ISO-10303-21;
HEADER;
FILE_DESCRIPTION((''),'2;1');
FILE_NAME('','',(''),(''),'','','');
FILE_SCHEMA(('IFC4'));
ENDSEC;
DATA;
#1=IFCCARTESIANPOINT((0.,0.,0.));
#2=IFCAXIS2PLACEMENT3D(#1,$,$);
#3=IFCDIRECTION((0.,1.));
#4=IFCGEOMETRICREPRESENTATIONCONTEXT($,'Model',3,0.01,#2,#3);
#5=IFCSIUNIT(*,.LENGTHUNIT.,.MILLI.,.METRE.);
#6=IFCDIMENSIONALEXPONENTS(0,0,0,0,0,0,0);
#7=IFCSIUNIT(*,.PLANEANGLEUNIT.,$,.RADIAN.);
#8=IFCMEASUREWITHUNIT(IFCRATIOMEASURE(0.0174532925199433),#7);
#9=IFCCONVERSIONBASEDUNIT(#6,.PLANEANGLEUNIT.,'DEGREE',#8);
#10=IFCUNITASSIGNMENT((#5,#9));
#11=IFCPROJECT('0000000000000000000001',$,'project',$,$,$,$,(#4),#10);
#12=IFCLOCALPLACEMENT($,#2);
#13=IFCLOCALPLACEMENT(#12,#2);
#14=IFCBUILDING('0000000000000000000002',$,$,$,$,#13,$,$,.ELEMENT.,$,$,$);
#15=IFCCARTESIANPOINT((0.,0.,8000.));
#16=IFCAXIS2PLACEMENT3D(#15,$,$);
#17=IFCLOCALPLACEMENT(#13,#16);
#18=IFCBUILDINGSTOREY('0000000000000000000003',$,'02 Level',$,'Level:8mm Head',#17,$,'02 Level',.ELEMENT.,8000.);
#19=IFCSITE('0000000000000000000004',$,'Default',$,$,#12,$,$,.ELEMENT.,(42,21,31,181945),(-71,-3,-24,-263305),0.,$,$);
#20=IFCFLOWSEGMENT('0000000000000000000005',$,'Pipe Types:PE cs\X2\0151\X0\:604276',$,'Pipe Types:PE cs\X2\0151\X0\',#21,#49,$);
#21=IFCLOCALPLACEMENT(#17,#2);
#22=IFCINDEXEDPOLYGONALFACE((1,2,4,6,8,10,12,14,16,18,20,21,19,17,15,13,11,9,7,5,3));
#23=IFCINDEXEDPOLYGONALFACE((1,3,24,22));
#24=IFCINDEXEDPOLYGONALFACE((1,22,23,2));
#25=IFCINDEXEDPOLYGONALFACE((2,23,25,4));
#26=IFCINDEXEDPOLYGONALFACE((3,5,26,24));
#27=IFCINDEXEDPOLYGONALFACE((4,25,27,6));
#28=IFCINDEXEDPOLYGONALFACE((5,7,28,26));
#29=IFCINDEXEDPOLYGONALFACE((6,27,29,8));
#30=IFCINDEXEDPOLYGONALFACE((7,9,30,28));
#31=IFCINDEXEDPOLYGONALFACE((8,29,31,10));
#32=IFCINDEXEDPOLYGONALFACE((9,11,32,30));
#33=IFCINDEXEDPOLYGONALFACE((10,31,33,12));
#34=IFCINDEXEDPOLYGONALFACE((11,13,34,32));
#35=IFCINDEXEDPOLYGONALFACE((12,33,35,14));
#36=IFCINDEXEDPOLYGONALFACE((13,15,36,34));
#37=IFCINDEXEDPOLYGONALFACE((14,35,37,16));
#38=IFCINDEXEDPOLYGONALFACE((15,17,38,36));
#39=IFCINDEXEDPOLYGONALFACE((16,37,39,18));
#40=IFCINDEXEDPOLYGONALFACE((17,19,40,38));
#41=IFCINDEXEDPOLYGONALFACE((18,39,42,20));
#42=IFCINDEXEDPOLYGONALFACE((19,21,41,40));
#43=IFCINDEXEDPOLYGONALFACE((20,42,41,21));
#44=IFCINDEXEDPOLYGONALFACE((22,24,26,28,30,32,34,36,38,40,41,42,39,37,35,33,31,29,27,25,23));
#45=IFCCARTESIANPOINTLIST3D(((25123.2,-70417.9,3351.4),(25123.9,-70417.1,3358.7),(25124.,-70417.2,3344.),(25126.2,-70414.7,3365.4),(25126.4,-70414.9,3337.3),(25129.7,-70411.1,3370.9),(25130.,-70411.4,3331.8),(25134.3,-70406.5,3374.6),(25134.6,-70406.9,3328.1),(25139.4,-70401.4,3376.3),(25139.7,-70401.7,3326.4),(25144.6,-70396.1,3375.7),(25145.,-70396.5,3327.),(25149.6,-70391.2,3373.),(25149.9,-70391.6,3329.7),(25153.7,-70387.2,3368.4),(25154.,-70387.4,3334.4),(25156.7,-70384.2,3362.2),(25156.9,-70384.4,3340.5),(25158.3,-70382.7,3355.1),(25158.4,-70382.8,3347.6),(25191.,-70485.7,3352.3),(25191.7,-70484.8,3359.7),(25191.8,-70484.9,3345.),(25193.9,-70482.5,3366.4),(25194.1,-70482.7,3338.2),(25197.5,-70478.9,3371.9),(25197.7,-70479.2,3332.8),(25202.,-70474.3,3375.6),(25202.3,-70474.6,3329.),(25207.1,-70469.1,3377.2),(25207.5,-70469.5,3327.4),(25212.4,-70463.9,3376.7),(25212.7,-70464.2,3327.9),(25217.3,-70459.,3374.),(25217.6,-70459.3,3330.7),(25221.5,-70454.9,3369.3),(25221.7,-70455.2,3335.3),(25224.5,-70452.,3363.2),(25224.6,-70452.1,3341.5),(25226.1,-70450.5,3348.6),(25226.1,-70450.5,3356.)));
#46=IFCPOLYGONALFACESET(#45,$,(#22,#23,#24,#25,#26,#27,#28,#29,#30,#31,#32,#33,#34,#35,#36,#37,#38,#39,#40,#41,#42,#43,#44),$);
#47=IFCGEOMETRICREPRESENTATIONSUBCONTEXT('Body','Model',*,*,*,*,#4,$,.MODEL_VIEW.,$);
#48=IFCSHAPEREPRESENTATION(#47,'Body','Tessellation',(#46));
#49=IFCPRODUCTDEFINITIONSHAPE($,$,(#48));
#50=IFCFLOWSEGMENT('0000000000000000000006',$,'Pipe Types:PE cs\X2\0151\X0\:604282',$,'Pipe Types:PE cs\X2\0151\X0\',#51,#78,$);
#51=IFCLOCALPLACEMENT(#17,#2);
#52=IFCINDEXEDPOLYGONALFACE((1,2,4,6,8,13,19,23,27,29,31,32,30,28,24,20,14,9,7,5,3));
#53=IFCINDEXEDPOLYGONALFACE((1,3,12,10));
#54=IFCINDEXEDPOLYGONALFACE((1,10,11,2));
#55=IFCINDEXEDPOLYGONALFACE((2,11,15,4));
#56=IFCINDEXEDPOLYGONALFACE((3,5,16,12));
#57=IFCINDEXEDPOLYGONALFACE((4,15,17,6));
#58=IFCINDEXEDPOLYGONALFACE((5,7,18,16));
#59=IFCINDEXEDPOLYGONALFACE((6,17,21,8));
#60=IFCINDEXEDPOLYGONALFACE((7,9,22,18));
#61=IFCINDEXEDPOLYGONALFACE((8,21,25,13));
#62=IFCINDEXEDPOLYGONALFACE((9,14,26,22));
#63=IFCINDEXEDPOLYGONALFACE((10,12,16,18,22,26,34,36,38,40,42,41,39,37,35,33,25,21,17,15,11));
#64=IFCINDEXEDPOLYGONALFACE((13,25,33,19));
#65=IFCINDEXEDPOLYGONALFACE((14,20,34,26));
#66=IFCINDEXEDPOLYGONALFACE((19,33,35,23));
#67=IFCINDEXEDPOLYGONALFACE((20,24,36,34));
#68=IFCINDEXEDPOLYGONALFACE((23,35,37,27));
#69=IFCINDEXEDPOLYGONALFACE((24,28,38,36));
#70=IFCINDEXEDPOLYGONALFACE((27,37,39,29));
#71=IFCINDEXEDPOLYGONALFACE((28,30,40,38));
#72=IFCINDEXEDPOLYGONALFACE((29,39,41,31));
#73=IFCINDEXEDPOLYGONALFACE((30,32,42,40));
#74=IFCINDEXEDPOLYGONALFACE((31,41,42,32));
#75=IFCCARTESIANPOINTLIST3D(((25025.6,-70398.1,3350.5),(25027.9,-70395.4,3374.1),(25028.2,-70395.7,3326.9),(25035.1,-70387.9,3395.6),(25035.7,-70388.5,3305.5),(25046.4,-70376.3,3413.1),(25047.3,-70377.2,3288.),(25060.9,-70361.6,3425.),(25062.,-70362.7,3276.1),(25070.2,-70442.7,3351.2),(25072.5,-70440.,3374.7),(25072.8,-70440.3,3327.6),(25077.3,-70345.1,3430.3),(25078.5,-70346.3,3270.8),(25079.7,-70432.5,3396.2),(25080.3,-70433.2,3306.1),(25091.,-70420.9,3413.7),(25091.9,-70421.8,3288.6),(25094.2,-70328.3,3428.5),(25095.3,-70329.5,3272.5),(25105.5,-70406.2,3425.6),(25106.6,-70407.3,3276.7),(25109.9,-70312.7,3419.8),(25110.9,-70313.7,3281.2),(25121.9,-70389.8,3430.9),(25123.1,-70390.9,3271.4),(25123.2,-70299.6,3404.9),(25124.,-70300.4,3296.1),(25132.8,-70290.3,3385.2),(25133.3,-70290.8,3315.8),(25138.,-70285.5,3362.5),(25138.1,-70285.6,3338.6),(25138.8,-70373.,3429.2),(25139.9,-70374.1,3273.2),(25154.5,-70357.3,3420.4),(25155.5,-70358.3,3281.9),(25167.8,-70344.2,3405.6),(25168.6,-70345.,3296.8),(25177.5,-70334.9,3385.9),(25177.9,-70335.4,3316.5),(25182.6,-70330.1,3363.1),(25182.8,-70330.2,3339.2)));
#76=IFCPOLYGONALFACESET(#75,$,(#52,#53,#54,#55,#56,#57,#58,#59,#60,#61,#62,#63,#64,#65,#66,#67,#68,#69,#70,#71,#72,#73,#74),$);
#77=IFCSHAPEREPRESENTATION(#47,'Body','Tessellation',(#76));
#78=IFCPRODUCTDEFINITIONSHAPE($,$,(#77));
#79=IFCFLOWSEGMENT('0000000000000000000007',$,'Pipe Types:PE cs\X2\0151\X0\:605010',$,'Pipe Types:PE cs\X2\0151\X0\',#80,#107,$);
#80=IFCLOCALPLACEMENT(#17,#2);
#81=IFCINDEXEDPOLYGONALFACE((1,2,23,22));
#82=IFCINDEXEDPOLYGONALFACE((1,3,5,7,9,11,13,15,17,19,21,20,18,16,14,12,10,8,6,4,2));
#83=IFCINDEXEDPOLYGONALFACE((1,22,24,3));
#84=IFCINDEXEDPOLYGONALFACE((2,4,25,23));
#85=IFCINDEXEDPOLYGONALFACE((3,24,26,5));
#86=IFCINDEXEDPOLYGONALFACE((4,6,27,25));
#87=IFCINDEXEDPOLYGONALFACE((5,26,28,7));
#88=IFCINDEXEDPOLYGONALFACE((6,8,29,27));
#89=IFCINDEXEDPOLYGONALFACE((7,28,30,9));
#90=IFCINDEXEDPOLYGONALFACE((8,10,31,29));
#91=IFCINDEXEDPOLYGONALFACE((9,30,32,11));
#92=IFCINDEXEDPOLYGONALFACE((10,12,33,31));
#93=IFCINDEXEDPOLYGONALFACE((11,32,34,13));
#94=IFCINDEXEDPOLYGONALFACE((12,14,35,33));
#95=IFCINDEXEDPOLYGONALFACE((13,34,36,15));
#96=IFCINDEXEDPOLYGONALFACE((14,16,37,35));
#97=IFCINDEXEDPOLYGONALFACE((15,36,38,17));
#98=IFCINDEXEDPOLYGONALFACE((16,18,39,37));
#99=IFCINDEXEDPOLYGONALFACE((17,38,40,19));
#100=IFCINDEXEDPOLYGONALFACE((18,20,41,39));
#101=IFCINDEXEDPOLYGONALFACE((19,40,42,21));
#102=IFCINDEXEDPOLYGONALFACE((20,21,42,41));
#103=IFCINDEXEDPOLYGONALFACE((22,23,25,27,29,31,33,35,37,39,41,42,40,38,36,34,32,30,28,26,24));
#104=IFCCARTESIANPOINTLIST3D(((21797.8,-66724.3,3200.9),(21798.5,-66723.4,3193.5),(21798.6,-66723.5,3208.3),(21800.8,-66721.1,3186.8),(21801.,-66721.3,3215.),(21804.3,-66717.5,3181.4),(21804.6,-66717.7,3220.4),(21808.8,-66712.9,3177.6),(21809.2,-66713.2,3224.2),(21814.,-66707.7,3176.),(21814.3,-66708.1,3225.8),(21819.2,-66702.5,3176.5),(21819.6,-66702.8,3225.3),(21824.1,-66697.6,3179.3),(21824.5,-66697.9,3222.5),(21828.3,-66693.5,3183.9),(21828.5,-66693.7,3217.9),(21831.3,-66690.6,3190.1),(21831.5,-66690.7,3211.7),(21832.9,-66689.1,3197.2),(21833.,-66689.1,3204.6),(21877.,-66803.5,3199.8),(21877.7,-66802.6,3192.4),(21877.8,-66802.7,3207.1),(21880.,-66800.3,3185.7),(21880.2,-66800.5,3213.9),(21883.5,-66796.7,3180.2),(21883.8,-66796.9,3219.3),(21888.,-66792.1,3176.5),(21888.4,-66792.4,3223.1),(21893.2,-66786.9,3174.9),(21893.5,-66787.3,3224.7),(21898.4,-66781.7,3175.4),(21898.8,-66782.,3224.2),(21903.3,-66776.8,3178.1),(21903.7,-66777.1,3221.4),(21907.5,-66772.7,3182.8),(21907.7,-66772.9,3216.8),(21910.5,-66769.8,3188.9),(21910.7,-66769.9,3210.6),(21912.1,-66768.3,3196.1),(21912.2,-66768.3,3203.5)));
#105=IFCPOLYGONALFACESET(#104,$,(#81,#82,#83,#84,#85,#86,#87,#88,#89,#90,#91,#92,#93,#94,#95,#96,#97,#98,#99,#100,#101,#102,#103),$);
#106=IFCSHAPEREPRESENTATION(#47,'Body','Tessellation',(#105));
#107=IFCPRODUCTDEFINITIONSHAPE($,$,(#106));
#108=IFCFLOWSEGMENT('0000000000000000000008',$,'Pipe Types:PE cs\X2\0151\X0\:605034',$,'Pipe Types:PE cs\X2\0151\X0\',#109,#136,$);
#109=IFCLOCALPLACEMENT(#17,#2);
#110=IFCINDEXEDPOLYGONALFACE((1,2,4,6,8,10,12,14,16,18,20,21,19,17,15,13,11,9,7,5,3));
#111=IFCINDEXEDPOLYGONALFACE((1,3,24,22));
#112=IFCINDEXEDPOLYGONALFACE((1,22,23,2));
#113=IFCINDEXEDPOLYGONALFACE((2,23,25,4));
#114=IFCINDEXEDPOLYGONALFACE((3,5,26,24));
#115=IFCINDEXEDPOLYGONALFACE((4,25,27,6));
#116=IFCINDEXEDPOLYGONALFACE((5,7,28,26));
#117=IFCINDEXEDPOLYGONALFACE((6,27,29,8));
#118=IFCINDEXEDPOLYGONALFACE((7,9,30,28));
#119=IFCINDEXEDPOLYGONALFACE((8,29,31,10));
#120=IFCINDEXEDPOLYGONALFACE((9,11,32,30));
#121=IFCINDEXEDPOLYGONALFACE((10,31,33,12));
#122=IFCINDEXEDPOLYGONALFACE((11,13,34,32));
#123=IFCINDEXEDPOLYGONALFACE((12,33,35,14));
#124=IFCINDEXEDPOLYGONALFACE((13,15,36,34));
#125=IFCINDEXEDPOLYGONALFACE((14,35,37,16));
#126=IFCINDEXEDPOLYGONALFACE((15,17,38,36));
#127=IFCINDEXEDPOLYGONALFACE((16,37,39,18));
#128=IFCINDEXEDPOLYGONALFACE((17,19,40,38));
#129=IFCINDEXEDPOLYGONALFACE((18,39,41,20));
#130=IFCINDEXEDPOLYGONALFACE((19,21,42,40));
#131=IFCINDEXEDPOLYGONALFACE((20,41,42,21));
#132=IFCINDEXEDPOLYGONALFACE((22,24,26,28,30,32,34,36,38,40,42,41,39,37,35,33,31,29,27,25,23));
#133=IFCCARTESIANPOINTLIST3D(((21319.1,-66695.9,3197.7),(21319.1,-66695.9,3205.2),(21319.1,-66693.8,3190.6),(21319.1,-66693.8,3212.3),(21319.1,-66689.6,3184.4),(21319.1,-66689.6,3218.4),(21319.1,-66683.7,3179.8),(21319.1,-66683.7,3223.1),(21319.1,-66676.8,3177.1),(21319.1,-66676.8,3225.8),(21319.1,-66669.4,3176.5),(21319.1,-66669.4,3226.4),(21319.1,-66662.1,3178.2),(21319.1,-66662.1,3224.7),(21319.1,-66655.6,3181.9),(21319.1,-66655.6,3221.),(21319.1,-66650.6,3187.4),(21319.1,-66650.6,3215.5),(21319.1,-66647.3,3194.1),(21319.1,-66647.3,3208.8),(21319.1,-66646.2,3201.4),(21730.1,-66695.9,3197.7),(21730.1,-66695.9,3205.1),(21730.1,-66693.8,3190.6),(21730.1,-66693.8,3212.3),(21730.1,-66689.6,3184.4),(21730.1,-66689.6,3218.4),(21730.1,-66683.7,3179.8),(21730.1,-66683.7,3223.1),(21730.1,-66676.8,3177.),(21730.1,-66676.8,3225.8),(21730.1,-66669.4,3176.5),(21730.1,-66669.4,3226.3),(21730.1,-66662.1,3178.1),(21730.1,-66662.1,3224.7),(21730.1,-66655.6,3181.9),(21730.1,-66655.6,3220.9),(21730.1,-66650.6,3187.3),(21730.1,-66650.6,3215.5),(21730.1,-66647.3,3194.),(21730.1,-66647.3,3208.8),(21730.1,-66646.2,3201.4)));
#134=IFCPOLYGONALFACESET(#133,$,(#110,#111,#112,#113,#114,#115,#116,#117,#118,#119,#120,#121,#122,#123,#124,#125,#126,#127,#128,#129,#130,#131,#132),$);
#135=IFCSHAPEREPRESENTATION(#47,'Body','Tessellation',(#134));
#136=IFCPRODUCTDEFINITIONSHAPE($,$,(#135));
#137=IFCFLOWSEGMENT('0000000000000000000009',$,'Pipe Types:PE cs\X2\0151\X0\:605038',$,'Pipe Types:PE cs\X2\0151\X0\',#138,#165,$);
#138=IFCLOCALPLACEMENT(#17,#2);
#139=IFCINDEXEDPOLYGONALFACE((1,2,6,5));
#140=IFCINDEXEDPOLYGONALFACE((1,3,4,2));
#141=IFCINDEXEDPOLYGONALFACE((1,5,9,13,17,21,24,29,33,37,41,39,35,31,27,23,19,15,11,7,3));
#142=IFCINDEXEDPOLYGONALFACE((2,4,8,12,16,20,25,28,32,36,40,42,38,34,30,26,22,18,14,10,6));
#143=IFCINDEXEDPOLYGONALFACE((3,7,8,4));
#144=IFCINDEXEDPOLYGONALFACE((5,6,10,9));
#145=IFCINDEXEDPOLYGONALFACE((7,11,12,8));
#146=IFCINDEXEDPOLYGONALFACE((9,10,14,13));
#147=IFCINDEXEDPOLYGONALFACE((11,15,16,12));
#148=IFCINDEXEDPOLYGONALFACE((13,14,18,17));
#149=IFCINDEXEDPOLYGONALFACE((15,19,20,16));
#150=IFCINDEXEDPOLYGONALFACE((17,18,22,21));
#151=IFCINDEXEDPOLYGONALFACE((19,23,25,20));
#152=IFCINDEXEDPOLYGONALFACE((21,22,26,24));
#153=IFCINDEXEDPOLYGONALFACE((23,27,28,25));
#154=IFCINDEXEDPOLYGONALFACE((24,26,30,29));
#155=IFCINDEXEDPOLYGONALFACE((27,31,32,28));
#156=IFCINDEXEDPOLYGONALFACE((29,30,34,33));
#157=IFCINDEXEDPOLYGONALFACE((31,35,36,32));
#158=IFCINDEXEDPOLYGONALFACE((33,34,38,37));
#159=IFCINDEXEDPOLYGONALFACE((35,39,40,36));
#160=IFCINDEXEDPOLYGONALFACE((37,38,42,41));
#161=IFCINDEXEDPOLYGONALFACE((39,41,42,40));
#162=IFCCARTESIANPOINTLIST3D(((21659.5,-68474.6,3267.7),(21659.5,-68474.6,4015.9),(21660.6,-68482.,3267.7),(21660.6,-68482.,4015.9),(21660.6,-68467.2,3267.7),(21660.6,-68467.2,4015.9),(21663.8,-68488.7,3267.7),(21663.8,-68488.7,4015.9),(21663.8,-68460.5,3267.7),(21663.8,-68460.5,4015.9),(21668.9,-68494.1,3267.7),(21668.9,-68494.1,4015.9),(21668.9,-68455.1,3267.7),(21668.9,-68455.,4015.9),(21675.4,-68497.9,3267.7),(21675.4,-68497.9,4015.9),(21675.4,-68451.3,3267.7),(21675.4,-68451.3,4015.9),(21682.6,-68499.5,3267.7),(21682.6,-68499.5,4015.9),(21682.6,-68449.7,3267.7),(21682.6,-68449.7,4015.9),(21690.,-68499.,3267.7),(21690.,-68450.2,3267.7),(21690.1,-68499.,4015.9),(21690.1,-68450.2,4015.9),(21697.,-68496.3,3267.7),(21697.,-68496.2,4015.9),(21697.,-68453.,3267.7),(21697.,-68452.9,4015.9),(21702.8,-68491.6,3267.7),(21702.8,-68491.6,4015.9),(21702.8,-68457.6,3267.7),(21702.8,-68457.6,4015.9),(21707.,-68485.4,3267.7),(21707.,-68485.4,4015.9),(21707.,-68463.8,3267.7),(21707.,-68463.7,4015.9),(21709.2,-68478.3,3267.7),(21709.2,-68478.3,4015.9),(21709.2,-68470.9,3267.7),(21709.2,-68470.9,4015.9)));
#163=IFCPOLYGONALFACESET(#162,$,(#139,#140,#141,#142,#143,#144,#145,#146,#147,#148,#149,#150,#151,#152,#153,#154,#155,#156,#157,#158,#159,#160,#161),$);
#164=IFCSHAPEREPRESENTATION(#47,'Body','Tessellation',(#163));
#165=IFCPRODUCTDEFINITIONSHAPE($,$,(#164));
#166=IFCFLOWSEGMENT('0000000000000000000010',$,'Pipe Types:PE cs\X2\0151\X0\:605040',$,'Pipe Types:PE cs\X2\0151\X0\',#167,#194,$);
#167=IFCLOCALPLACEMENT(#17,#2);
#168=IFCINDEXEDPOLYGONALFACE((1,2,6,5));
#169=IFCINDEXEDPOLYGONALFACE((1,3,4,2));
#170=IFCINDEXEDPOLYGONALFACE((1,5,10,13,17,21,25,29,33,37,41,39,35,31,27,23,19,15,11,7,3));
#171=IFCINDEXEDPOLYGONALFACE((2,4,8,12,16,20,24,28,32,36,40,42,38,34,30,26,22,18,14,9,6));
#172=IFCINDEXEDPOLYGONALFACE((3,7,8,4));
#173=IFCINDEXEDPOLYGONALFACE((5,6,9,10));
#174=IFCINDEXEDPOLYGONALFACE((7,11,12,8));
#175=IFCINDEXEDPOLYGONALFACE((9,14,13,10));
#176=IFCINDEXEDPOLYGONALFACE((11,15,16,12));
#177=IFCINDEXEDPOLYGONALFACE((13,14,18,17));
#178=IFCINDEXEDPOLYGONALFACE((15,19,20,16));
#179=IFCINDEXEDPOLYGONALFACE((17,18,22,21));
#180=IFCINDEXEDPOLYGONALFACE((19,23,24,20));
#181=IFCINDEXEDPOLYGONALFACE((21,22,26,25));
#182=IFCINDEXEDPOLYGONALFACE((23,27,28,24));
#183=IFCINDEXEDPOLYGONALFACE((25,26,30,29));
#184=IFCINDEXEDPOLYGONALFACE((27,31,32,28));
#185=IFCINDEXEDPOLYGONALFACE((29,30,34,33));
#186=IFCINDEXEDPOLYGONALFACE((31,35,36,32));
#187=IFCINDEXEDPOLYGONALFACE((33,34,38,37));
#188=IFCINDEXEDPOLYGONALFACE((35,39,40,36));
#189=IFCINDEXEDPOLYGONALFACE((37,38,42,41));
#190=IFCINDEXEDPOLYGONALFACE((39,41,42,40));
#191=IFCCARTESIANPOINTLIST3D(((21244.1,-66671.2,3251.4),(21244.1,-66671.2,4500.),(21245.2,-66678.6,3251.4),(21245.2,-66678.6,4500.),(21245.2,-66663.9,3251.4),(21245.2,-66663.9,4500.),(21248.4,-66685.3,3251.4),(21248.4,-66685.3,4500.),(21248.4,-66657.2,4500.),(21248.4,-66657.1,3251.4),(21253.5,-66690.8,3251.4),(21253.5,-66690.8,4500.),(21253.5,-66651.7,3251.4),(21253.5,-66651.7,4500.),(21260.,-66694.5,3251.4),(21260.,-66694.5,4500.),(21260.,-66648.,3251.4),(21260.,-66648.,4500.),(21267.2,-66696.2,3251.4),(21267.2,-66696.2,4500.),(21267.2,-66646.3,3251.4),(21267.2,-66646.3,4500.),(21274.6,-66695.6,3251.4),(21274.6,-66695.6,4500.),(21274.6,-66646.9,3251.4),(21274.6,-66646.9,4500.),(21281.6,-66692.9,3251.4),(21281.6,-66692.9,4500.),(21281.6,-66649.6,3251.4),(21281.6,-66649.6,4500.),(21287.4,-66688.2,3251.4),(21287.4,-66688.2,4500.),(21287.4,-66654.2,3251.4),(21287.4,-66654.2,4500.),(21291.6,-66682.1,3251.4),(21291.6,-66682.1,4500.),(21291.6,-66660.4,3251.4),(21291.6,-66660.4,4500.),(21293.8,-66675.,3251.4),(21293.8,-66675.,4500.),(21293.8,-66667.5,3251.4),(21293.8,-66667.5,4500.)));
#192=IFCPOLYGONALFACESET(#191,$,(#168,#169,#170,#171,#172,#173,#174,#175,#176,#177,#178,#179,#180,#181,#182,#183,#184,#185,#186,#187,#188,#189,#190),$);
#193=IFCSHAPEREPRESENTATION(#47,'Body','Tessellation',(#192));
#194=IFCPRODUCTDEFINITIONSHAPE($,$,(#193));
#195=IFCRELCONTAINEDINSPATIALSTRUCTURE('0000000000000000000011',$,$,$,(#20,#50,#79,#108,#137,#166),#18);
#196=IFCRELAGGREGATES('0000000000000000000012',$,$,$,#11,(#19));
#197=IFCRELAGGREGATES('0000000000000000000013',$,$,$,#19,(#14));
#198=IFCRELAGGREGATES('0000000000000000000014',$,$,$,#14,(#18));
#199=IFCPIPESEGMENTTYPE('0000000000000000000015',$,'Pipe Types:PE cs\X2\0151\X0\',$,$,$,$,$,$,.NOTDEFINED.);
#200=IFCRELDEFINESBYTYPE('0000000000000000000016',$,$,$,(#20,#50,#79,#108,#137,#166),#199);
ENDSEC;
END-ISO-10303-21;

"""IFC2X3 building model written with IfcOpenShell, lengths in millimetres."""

from ifc_helpers import new_model, entity, si_unit, converted_unit, direction, frame, frame_2d, origin, origin_2d_with_axis, place, context, subcontext, project, spatial, circle, extrude, type_object, element, save


model = new_model("IFC2X3")

# Units and contexts
model_context = context("Model", 3, precision=0.01, world=origin(), true_north=direction((0.0, 1.0)))
body_context = subcontext(model_context, "Body", "Model", "MODEL_VIEW")
ifc_project = project(units=[si_unit("LENGTHUNIT", "METRE", prefix="MILLI"), converted_unit("PLANEANGLEUNIT", "DEGREE", entity("IfcRatioMeasure", 0.0174532925199433), si_unit("PLANEANGLEUNIT", "RADIAN"), dimensions=[0, 0, 0, 0, 0, 0, 0])], contexts=[model_context])

# Site, building, storey
site_placement = place(None, origin())
site = spatial("IfcSite", under=ifc_project, at=site_placement, Name="Default", CompositionType="ELEMENT", RefLatitude=(42, 21, 31, 181945), RefLongitude=(-71, -3, -24, -263305), RefElevation=0.0)
building_placement = place(site_placement, origin())
building = spatial("IfcBuilding", under=site, at=building_placement, CompositionType="ELEMENT")
storey_placement = place(building_placement, frame((0.0, 0.0, 8000.0)))
storey = spatial("IfcBuildingStorey", under=building, at=storey_placement, Name="02 Level", ObjectType="Level:8mm Head", LongName="02 Level", CompositionType="ELEMENT", Elevation=8000.0)

# Flow segments
pipe_segment_type = type_object("IfcPipeSegmentType", Name="Pipe Types:PE cső", PredefinedType="NOTDEFINED")
flow_segment_1_placement = place(storey_placement, frame((25121.6, -70487.3, 3324.8)))
element("IfcFlowSegment", 1, at=flow_segment_1_placement, inside=storey, type_object=pipe_segment_type, Name="Pipe Types:PE cső:604276", ObjectType="Pipe Types:PE cső", context=body_context, shape_type="SweptSolid", body=[
    extrude(circle(Radius=25.0, at=frame_2d((0.0, 0.0), x_axis=(1.0, 0.0))), frame((87.0, 19.3, 27.6), z_axis=(-0.707072, 0.707071, -0.009982), x_axis=(-0.707107, -0.707107, 0.0)), (0.0, 0.0, 1.0), 95.8),
])
flow_segment_2_placement = place(storey_placement, frame((25024.0, -70444.3, 3268.9)))
element("IfcFlowSegment", 2, at=flow_segment_2_placement, inside=storey, type_object=pipe_segment_type, Name="Pipe Types:PE cső:604282", ObjectType="Pipe Types:PE cső", context=body_context, shape_type="SweptSolid", body=[
    extrude(circle(Radius=80.0, at=origin_2d_with_axis()), frame((58.2, 102.8, 81.6), z_axis=(0.707071, -0.707071, 0.010046), x_axis=(-0.707107, -0.707107, 0.0)), (0.0, 0.0, 1.0), 63.1),
])
flow_segment_3_placement = place(storey_placement, frame((21796.2, -66805.1, 3173.2)))
element("IfcFlowSegment", 3, at=flow_segment_3_placement, inside=storey, type_object=pipe_segment_type, Name="Pipe Types:PE cső:605010", ObjectType="Pipe Types:PE cső", context=body_context, shape_type="SweptSolid", body=[
    extrude(circle(Radius=25.0, at=origin_2d_with_axis()), frame((98.5, 19.3, 26.6), z_axis=(-0.707071, 0.707071, 0.01), x_axis=(-0.707107, -0.707107, 0.0)), (0.0, 0.0, 1.0), 112.0),
])
flow_segment_4_placement = place(storey_placement, frame((21319.1, -66697.8, 3174.8)))
element("IfcFlowSegment", 4, at=flow_segment_4_placement, inside=storey, type_object=pipe_segment_type, Name="Pipe Types:PE cső:605034", ObjectType="Pipe Types:PE cső", context=body_context, shape_type="SweptSolid", body=[
    extrude(circle(Radius=25.0, at=frame_2d((0.0, 0.0), x_axis=(1.0, 0.0))), frame((0.0, 26.6, 26.6), z_axis=(1.0, 0.0, -0.000085), x_axis=(0.0, 1.0, 0.0)), (0.0, 0.0, 1.0), 411.0),
])
flow_segment_5_placement = place(storey_placement, frame((21657.9, -68501.2, 3267.7)))
element("IfcFlowSegment", 5, at=flow_segment_5_placement, inside=storey, type_object=pipe_segment_type, Name="Pipe Types:PE cső:605038", ObjectType="Pipe Types:PE cső", context=body_context, shape_type="SweptSolid", body=[
    extrude(circle(Radius=25.0, at=frame_2d((0.0, 0.0), x_axis=(1.0, 0.0))), frame((26.6, 26.6, 0.0), z_axis=(0.000019, 0.000019, 1.0), x_axis=(-1.0, 0.0, 0.000019)), (0.0, 0.0, 1.0), 748.2),
])
flow_segment_6_placement = place(storey_placement, frame((21242.5, -66697.8, 3251.4)))
element("IfcFlowSegment", 6, at=flow_segment_6_placement, inside=storey, type_object=pipe_segment_type, Name="Pipe Types:PE cső:605040", ObjectType="Pipe Types:PE cső", context=body_context, shape_type="SweptSolid", body=[
    extrude(circle(Radius=25.0, at=origin_2d_with_axis()), frame((26.6, 26.6, 0.0), z_axis=(0.0, -0.000009, 1.0), x_axis=(-1.0, 0.0, 0.0)), (0.0, 0.0, 1.0), 1248.6),
])

save(model, "model.ifc")
